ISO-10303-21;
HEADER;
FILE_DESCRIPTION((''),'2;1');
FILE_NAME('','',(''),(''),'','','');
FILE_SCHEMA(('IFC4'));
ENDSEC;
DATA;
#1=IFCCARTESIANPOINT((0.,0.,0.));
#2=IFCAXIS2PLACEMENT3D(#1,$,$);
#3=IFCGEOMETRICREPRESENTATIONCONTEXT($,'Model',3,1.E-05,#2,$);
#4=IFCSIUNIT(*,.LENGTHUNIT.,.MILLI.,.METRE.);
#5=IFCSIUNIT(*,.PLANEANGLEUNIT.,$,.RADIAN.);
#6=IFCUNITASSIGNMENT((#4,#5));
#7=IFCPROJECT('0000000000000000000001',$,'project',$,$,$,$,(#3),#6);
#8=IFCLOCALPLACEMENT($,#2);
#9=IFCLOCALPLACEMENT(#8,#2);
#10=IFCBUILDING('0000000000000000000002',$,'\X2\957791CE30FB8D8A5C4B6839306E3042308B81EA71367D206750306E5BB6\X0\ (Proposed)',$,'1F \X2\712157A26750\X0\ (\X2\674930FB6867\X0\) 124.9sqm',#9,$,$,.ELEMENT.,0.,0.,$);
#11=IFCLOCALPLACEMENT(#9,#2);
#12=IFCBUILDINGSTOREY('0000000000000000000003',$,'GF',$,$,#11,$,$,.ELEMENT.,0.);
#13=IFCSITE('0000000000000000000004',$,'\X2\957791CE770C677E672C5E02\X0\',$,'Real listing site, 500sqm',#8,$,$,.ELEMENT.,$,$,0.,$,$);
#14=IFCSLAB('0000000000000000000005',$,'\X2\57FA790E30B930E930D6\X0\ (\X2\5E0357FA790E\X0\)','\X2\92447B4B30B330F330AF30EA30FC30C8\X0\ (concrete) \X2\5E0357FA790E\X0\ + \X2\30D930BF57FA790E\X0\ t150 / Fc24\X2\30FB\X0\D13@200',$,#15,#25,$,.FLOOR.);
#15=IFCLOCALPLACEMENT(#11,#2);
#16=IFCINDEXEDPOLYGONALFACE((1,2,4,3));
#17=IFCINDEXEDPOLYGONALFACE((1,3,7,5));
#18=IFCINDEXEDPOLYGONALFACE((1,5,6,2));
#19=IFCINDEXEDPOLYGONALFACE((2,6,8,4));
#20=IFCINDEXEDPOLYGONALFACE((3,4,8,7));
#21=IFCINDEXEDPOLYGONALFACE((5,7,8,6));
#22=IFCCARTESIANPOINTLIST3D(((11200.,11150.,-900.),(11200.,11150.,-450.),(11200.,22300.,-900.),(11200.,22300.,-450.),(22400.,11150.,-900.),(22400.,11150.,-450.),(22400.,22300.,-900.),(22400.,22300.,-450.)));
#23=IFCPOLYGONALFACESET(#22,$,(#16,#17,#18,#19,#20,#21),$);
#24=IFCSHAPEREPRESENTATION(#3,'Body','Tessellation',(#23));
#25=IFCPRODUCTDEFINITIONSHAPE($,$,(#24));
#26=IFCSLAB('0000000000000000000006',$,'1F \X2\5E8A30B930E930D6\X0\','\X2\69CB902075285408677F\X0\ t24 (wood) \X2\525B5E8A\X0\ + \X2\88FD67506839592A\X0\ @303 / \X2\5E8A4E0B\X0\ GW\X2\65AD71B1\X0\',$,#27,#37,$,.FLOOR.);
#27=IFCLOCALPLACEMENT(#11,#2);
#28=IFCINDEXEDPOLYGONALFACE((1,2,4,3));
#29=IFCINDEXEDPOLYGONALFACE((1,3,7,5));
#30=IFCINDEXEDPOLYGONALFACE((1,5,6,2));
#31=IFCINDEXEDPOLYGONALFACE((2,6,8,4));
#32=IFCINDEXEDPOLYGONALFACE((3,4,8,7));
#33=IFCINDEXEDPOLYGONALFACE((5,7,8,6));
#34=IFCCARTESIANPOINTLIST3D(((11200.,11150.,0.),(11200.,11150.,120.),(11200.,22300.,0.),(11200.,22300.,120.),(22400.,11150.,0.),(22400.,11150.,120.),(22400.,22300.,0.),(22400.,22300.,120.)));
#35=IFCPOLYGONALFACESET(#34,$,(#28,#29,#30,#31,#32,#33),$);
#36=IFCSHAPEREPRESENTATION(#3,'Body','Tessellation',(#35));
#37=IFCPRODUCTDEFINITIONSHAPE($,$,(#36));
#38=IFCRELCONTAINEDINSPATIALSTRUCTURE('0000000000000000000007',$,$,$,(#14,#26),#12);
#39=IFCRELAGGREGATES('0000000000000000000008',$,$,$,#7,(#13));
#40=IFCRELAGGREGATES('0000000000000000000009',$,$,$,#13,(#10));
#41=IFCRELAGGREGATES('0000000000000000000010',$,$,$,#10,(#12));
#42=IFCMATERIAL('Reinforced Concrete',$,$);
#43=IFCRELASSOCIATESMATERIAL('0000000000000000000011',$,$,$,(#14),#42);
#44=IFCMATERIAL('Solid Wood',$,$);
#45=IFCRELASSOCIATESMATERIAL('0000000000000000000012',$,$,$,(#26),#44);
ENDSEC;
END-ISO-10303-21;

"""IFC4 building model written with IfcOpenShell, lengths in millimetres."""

from ifc_helpers import new_model, si_unit, frame, frame_2d, origin, place, context, project, spatial, rectangle, extrude, material, element, save


model = new_model("IFC4")

# Units and contexts
model_context = context("Model", 3, precision=1e-05, world=origin())
ifc_project = project(units=[si_unit("LENGTHUNIT", "METRE", prefix="MILLI"), si_unit("PLANEANGLEUNIT", "RADIAN")], contexts=[model_context])

# Site, building, storey
site_placement = place(None, origin())
site = spatial("IfcSite", under=ifc_project, at=site_placement, Name="長野県松本市", ObjectType="Real listing site, 500sqm", CompositionType="ELEMENT", RefElevation=0.0)
building_placement = place(site_placement, origin())
building = spatial("IfcBuilding", under=site, at=building_placement, Name="長野・越屋根のある自然素材の家 (Proposed)", ObjectType="1F 無垢材 (杉・桧) 124.9sqm", CompositionType="ELEMENT", ElevationOfRefHeight=0.0, ElevationOfTerrain=0.0)
storey_placement = place(building_placement, origin())
storey = spatial("IfcBuildingStorey", under=building, at=storey_placement, Name="GF", CompositionType="ELEMENT", Elevation=0.0)

# Shared definitions
ifc_material_1 = material(Name="Solid Wood")

# Slabs
ifc_material_2 = material(Name="Reinforced Concrete")
slab_1_placement = place(storey_placement, frame((5600.0, 5575.0, -450.0)))
element("IfcSlab", 1, at=slab_1_placement, inside=storey, material=ifc_material_2, Name="基礎スラブ (布基礎)", Description="鉄筋コンクリート (concrete) 布基礎 + ベタ基礎 t150 / Fc24・D13@200", PredefinedType="FLOOR", context=model_context, shape_type="SweptSolid", body=[
    extrude(rectangle(XDim=11200.0, YDim=11150.0, at=frame_2d((5600.0, 5575.0))), frame((5600.0, 5575.0, -450.0)), (0.0, 0.0, 1.0), 450.0),
])
slab_2_placement = place(storey_placement, frame((5600.0, 5575.0, 0.0)))
element("IfcSlab", 2, at=slab_2_placement, inside=storey, material=ifc_material_1, Name="1F 床スラブ", Description="構造用合板 t24 (wood) 剛床 + 製材根太 @303 / 床下 GW断熱", PredefinedType="FLOOR", context=model_context, shape_type="SweptSolid", body=[
    extrude(rectangle(XDim=11200.0, YDim=11150.0, at=frame_2d((5600.0, 5575.0))), frame((5600.0, 5575.0, 0.0)), (0.0, 0.0, 1.0), 120.0),
])

save(model, "model.ifc")
